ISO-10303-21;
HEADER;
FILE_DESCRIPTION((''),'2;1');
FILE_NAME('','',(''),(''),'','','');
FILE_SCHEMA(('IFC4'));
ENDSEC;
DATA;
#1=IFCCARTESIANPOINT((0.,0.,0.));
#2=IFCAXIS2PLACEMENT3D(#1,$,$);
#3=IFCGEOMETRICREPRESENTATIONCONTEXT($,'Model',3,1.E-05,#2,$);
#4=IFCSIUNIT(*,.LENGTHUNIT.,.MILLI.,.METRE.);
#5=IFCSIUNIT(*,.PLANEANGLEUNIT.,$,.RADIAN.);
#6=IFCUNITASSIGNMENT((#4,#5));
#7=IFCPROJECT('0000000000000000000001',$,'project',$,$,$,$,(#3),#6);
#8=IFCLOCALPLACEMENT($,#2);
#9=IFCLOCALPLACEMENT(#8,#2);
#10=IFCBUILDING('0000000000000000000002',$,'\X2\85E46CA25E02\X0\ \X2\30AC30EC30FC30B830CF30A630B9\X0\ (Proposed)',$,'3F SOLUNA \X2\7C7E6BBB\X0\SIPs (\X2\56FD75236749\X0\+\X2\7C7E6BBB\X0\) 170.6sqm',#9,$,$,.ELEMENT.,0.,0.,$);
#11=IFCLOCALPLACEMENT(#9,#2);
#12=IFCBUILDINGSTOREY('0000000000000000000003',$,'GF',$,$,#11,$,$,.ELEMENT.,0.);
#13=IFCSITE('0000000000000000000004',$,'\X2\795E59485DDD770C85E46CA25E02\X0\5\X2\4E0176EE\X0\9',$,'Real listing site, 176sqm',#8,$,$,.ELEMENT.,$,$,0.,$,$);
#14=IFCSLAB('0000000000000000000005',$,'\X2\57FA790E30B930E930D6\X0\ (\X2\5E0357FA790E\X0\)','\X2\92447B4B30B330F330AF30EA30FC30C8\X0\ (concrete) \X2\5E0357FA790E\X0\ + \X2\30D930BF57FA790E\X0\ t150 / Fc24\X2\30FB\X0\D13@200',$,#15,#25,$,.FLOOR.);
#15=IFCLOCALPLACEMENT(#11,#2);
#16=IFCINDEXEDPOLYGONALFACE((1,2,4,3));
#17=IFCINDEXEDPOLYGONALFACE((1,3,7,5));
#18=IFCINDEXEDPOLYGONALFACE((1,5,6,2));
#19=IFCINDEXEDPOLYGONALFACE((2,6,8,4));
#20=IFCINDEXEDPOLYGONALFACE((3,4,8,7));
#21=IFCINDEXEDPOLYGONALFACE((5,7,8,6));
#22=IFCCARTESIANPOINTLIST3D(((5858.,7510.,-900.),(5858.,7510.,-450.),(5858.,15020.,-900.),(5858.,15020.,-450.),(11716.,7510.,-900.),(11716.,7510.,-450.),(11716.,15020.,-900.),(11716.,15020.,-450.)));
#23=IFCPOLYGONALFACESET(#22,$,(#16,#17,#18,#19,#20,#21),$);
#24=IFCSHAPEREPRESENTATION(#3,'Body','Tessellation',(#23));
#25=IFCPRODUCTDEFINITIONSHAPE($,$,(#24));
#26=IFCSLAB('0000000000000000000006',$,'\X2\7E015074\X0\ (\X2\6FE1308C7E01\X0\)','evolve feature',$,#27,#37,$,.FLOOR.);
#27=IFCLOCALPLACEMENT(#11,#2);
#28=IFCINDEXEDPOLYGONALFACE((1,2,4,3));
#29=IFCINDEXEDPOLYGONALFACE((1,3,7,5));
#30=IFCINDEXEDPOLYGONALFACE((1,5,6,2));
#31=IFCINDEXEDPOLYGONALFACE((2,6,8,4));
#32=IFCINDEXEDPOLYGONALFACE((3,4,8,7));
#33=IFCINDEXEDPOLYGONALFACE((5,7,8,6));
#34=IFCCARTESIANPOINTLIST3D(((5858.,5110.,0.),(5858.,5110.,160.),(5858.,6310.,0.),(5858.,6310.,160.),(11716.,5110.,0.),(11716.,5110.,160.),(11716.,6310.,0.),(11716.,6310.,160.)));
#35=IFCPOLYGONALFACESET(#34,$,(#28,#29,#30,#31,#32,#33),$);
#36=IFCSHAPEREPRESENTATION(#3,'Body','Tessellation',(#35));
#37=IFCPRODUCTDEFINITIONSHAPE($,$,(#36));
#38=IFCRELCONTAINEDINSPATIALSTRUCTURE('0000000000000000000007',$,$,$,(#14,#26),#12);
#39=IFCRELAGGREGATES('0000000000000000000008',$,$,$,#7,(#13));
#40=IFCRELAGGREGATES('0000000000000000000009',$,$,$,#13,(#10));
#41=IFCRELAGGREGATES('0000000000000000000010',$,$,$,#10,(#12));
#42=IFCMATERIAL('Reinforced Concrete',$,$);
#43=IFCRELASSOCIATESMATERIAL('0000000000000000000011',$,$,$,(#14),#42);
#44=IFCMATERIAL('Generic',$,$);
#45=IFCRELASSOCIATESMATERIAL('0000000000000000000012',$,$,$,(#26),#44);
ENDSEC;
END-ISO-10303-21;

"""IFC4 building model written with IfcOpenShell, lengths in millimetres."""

from ifc_helpers import new_model, si_unit, frame, frame_2d, origin, place, context, project, spatial, rectangle, extrude, material, element, save


model = new_model("IFC4")

# Units and contexts
model_context = context("Model", 3, precision=1e-05, world=origin())
ifc_project = project(units=[si_unit("LENGTHUNIT", "METRE", prefix="MILLI"), si_unit("PLANEANGLEUNIT", "RADIAN")], contexts=[model_context])

# Site, building, storey
site_placement = place(None, origin())
site = spatial("IfcSite", under=ifc_project, at=site_placement, Name="神奈川県藤沢市5丁目9", ObjectType="Real listing site, 176sqm", CompositionType="ELEMENT", RefElevation=0.0)
building_placement = place(site_placement, origin())
building = spatial("IfcBuilding", under=site, at=building_placement, Name="藤沢市 ガレージハウス (Proposed)", ObjectType="3F SOLUNA 籾殻SIPs (国産杉+籾殻) 170.6sqm", CompositionType="ELEMENT", ElevationOfRefHeight=0.0, ElevationOfTerrain=0.0)
storey_placement = place(building_placement, origin())
storey = spatial("IfcBuildingStorey", under=building, at=storey_placement, Name="GF", CompositionType="ELEMENT", Elevation=0.0)

# Slabs
ifc_material_1 = material(Name="Reinforced Concrete")
slab_1_placement = place(storey_placement, frame((2929.0, 3755.0, -450.0)))
element("IfcSlab", 1, at=slab_1_placement, inside=storey, material=ifc_material_1, Name="基礎スラブ (布基礎)", Description="鉄筋コンクリート (concrete) 布基礎 + ベタ基礎 t150 / Fc24・D13@200", PredefinedType="FLOOR", context=model_context, shape_type="SweptSolid", body=[
    extrude(rectangle(XDim=5858.0, YDim=7510.0, at=frame_2d((2929.0, 3755.0))), frame((2929.0, 3755.0, -450.0)), (0.0, 0.0, 1.0), 450.0),
])
ifc_material_2 = material(Name="Generic")
slab_2_placement = place(storey_placement, frame((2929.0, 2555.0, 0.0)))
element("IfcSlab", 2, at=slab_2_placement, inside=storey, material=ifc_material_2, Name="縁側 (濡れ縁)", Description="evolve feature", PredefinedType="FLOOR", context=model_context, shape_type="SweptSolid", body=[
    extrude(rectangle(XDim=5858.0, YDim=1200.0, at=frame_2d((2929.0, 600.0))), frame((2929.0, 2555.0, 0.0)), (0.0, 0.0, 1.0), 160.0),
])

save(model, "model.ifc")
